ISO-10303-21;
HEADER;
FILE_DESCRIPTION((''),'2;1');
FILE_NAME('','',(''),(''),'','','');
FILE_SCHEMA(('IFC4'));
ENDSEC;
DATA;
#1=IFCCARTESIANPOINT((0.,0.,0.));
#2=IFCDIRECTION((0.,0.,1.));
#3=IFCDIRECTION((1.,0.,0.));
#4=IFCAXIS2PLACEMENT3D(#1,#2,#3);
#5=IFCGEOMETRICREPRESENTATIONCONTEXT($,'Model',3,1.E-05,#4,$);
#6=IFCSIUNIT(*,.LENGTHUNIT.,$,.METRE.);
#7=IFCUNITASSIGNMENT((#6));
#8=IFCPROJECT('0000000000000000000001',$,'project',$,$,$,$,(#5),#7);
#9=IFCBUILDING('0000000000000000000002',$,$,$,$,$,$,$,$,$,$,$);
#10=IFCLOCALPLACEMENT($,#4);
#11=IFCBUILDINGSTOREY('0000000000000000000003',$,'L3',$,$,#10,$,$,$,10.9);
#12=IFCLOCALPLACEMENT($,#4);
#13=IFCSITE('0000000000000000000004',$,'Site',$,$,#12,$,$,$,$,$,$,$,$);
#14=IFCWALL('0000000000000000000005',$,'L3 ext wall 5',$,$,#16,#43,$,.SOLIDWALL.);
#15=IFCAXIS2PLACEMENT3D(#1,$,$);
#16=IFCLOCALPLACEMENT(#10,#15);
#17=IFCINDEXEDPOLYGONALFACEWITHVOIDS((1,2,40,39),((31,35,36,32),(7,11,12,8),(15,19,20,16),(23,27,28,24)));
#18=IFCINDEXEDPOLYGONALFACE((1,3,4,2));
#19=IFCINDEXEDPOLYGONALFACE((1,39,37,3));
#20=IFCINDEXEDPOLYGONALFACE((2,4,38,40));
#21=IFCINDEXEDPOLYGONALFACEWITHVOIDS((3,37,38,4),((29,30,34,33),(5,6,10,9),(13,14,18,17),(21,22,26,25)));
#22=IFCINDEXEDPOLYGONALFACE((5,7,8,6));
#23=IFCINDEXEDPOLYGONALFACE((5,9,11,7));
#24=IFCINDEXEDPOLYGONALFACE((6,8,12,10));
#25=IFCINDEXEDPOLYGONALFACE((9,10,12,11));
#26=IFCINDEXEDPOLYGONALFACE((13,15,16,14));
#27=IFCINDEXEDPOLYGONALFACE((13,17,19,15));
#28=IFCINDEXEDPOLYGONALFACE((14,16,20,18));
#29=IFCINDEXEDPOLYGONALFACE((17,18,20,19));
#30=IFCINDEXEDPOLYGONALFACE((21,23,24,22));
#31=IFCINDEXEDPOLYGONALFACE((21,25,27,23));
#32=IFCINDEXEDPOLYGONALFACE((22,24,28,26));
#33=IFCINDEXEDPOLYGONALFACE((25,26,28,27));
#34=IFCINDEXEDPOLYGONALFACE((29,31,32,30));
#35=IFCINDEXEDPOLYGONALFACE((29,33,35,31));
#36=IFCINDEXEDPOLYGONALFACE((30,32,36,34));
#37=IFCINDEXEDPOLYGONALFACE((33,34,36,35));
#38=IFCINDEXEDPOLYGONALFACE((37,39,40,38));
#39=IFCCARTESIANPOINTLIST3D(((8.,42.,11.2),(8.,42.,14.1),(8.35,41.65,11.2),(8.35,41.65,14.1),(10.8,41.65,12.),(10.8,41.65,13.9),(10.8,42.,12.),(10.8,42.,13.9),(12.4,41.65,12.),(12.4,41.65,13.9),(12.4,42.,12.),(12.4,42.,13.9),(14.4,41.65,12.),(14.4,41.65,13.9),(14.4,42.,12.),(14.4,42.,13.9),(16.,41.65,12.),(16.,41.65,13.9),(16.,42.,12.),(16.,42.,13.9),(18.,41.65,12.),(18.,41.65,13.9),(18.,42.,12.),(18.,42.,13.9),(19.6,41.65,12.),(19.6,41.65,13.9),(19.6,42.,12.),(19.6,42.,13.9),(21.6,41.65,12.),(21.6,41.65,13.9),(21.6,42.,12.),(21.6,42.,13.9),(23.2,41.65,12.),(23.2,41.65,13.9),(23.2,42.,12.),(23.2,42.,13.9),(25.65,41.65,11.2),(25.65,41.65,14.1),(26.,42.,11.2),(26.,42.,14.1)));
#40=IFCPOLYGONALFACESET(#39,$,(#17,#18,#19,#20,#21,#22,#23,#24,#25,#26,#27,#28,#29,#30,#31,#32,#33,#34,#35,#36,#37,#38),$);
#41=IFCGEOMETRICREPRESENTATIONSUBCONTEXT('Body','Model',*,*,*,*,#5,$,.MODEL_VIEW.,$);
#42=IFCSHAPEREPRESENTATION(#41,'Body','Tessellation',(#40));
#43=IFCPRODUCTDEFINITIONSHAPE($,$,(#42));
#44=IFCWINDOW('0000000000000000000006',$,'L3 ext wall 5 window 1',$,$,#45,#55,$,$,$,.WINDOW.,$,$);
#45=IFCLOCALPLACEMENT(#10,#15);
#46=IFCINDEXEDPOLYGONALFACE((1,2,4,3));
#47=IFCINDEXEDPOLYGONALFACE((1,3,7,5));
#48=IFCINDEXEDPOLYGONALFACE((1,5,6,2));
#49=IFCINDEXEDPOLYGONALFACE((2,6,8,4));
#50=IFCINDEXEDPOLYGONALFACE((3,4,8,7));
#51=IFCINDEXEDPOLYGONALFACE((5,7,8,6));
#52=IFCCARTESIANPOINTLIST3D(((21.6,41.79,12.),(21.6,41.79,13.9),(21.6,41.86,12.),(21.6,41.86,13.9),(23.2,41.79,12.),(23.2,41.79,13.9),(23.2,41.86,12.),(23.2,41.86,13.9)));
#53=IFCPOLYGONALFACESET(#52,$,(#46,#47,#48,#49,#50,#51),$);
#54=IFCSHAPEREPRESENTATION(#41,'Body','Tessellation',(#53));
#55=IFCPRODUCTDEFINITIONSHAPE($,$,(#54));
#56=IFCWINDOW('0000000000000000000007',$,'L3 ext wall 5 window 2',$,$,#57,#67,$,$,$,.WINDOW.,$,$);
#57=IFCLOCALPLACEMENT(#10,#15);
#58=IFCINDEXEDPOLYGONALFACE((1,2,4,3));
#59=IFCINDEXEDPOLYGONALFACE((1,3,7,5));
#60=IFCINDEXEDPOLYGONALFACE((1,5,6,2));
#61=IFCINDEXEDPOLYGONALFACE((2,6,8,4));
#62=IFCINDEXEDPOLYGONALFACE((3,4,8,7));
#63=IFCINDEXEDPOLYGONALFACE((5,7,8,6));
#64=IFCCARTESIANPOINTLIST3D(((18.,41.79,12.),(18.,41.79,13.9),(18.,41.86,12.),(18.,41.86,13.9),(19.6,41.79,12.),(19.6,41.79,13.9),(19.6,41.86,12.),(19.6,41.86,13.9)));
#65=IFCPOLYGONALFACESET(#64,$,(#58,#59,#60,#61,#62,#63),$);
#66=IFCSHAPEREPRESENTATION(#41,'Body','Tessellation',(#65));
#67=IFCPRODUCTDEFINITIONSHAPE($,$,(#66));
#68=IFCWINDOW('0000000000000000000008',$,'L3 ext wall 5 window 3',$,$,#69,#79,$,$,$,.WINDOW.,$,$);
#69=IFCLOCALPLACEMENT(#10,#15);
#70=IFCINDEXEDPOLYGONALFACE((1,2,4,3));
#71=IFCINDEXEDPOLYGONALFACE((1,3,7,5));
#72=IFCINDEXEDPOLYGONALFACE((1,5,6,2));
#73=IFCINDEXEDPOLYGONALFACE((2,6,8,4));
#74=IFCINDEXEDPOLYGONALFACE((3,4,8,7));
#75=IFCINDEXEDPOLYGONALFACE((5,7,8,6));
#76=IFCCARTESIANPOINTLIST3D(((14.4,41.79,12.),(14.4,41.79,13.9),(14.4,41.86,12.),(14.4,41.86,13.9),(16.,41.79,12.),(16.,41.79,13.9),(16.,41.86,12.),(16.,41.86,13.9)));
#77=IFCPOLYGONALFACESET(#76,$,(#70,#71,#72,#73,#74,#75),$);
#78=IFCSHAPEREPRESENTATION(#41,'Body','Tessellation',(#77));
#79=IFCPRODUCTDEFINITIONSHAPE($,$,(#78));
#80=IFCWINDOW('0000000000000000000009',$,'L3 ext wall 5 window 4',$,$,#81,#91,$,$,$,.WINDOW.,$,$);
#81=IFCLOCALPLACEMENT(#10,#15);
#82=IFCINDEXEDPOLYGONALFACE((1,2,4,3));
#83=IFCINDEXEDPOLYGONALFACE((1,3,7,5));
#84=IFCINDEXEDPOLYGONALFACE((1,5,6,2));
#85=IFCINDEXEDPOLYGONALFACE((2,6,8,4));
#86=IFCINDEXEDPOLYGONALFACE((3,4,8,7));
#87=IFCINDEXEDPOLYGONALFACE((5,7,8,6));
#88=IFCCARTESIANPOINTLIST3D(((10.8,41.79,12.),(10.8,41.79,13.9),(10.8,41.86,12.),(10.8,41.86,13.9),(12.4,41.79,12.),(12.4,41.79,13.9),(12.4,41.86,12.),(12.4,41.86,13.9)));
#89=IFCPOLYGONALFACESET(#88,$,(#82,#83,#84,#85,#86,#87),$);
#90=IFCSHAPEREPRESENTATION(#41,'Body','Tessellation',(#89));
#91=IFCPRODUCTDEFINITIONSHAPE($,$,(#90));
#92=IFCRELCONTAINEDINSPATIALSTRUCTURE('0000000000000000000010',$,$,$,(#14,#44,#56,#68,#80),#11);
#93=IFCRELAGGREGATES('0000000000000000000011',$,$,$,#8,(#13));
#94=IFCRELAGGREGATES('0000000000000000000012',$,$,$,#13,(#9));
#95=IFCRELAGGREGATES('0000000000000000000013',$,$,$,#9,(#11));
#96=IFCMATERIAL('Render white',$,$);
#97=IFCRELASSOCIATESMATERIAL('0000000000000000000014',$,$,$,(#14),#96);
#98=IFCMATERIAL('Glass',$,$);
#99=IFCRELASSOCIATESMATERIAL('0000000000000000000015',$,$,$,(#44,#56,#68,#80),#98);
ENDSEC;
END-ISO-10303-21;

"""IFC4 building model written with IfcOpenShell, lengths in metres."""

from ifc_helpers import new_model, si_unit, frame, origin_with_axes, place, context, subcontext, project, spatial, polyline, outline, extrude, material, element, fill, save


model = new_model("IFC4")

# Units and contexts
model_context = context("Model", 3, precision=1e-05, world=origin_with_axes())
body_context = subcontext(model_context, "Body", "Model", "MODEL_VIEW")
ifc_project = project(units=[si_unit("LENGTHUNIT", "METRE")], contexts=[model_context])

# Site, building, storey
site_placement = place(None, origin_with_axes())
site = spatial("IfcSite", under=ifc_project, at=site_placement, Name="Site")
building = spatial("IfcBuilding", under=site)
storey_placement = place(None, origin_with_axes())
storey = spatial("IfcBuildingStorey", under=building, at=storey_placement, Name="L3", Elevation=10.9)

# Wall, openings, windows
ifc_material_1 = material(Name="Render white")
wall_1_placement = place(storey_placement, origin_with_axes())
wall_1 = element("IfcWall", 1, at=wall_1_placement, inside=storey, material=ifc_material_1, Name="L3 ext wall 5", PredefinedType="SOLIDWALL", context=body_context, shape_type="SweptSolid", body=[
    extrude(outline(polyline([(26.0, 42.0), (8.0, 42.0), (8.35, 41.65), (25.65, 41.65), (26.0, 42.0)])), frame((0.0, 0.0, 11.2), z_axis=(0.0, 0.0, 1.0), x_axis=(1.0, 0.0, 0.0)), (0.0, 0.0, 1.0), 2.9),
])
opening_1_placement = place(wall_1_placement, origin_with_axes())
opening_1 = element("IfcOpeningElement", 2, at=opening_1_placement, cuts=wall_1, context=body_context, shape_type="SweptSolid", body=[
    extrude(outline(polyline([(23.2, 42.05), (21.6, 42.05), (21.6, 41.6), (23.2, 41.6), (23.2, 42.05)])), frame((0.0, 0.0, 12.0), z_axis=(0.0, 0.0, 1.0), x_axis=(1.0, 0.0, 0.0)), (0.0, 0.0, 1.0), 1.9),
])
opening_2_placement = place(wall_1_placement, origin_with_axes())
opening_2 = element("IfcOpeningElement", 3, at=opening_2_placement, cuts=wall_1, context=body_context, shape_type="SweptSolid", body=[
    extrude(outline(polyline([(19.6, 42.05), (18.0, 42.05), (18.0, 41.6), (19.6, 41.6), (19.6, 42.05)])), frame((0.0, 0.0, 12.0), z_axis=(0.0, 0.0, 1.0), x_axis=(1.0, 0.0, 0.0)), (0.0, 0.0, 1.0), 1.9),
])
opening_3_placement = place(wall_1_placement, origin_with_axes())
opening_3 = element("IfcOpeningElement", 4, at=opening_3_placement, cuts=wall_1, context=body_context, shape_type="SweptSolid", body=[
    extrude(outline(polyline([(16.0, 42.05), (14.4, 42.05), (14.4, 41.6), (16.0, 41.6), (16.0, 42.05)])), frame((0.0, 0.0, 12.0), z_axis=(0.0, 0.0, 1.0), x_axis=(1.0, 0.0, 0.0)), (0.0, 0.0, 1.0), 1.9),
])
opening_4_placement = place(wall_1_placement, origin_with_axes())
opening_4 = element("IfcOpeningElement", 5, at=opening_4_placement, cuts=wall_1, context=body_context, shape_type="SweptSolid", body=[
    extrude(outline(polyline([(12.4, 42.05), (10.8, 42.05), (10.8, 41.6), (12.4, 41.6), (12.4, 42.05)])), frame((0.0, 0.0, 12.0), z_axis=(0.0, 0.0, 1.0), x_axis=(1.0, 0.0, 0.0)), (0.0, 0.0, 1.0), 1.9),
])
ifc_material_2 = material(Name="Glass")
window_1_placement = place(storey_placement, origin_with_axes())
window_1 = element("IfcWindow", 6, at=window_1_placement, inside=storey, material=ifc_material_2, Name="L3 ext wall 5 window 1", PredefinedType="WINDOW", context=body_context, shape_type="SweptSolid", body=[
    extrude(outline(polyline([(23.2, 41.86), (21.6, 41.86), (21.6, 41.79), (23.2, 41.79), (23.2, 41.86)])), frame((0.0, 0.0, 12.0), z_axis=(0.0, 0.0, 1.0), x_axis=(1.0, 0.0, 0.0)), (0.0, 0.0, 1.0), 1.9),
])
fill(opening_1, window_1)
window_2_placement = place(storey_placement, origin_with_axes())
window_2 = element("IfcWindow", 7, at=window_2_placement, inside=storey, material=ifc_material_2, Name="L3 ext wall 5 window 2", PredefinedType="WINDOW", context=body_context, shape_type="SweptSolid", body=[
    extrude(outline(polyline([(19.6, 41.86), (18.0, 41.86), (18.0, 41.79), (19.6, 41.79), (19.6, 41.86)])), frame((0.0, 0.0, 12.0), z_axis=(0.0, 0.0, 1.0), x_axis=(1.0, 0.0, 0.0)), (0.0, 0.0, 1.0), 1.9),
])
fill(opening_2, window_2)
window_3_placement = place(storey_placement, origin_with_axes())
window_3 = element("IfcWindow", 8, at=window_3_placement, inside=storey, material=ifc_material_2, Name="L3 ext wall 5 window 3", PredefinedType="WINDOW", context=body_context, shape_type="SweptSolid", body=[
    extrude(outline(polyline([(16.0, 41.86), (14.4, 41.86), (14.4, 41.79), (16.0, 41.79), (16.0, 41.86)])), frame((0.0, 0.0, 12.0), z_axis=(0.0, 0.0, 1.0), x_axis=(1.0, 0.0, 0.0)), (0.0, 0.0, 1.0), 1.9),
])
fill(opening_3, window_3)
window_4_placement = place(storey_placement, origin_with_axes())
window_4 = element("IfcWindow", 9, at=window_4_placement, inside=storey, material=ifc_material_2, Name="L3 ext wall 5 window 4", PredefinedType="WINDOW", context=body_context, shape_type="SweptSolid", body=[
    extrude(outline(polyline([(12.4, 41.86), (10.8, 41.86), (10.8, 41.79), (12.4, 41.79), (12.4, 41.86)])), frame((0.0, 0.0, 12.0), z_axis=(0.0, 0.0, 1.0), x_axis=(1.0, 0.0, 0.0)), (0.0, 0.0, 1.0), 1.9),
])
fill(opening_4, window_4)

save(model, "model.ifc")
